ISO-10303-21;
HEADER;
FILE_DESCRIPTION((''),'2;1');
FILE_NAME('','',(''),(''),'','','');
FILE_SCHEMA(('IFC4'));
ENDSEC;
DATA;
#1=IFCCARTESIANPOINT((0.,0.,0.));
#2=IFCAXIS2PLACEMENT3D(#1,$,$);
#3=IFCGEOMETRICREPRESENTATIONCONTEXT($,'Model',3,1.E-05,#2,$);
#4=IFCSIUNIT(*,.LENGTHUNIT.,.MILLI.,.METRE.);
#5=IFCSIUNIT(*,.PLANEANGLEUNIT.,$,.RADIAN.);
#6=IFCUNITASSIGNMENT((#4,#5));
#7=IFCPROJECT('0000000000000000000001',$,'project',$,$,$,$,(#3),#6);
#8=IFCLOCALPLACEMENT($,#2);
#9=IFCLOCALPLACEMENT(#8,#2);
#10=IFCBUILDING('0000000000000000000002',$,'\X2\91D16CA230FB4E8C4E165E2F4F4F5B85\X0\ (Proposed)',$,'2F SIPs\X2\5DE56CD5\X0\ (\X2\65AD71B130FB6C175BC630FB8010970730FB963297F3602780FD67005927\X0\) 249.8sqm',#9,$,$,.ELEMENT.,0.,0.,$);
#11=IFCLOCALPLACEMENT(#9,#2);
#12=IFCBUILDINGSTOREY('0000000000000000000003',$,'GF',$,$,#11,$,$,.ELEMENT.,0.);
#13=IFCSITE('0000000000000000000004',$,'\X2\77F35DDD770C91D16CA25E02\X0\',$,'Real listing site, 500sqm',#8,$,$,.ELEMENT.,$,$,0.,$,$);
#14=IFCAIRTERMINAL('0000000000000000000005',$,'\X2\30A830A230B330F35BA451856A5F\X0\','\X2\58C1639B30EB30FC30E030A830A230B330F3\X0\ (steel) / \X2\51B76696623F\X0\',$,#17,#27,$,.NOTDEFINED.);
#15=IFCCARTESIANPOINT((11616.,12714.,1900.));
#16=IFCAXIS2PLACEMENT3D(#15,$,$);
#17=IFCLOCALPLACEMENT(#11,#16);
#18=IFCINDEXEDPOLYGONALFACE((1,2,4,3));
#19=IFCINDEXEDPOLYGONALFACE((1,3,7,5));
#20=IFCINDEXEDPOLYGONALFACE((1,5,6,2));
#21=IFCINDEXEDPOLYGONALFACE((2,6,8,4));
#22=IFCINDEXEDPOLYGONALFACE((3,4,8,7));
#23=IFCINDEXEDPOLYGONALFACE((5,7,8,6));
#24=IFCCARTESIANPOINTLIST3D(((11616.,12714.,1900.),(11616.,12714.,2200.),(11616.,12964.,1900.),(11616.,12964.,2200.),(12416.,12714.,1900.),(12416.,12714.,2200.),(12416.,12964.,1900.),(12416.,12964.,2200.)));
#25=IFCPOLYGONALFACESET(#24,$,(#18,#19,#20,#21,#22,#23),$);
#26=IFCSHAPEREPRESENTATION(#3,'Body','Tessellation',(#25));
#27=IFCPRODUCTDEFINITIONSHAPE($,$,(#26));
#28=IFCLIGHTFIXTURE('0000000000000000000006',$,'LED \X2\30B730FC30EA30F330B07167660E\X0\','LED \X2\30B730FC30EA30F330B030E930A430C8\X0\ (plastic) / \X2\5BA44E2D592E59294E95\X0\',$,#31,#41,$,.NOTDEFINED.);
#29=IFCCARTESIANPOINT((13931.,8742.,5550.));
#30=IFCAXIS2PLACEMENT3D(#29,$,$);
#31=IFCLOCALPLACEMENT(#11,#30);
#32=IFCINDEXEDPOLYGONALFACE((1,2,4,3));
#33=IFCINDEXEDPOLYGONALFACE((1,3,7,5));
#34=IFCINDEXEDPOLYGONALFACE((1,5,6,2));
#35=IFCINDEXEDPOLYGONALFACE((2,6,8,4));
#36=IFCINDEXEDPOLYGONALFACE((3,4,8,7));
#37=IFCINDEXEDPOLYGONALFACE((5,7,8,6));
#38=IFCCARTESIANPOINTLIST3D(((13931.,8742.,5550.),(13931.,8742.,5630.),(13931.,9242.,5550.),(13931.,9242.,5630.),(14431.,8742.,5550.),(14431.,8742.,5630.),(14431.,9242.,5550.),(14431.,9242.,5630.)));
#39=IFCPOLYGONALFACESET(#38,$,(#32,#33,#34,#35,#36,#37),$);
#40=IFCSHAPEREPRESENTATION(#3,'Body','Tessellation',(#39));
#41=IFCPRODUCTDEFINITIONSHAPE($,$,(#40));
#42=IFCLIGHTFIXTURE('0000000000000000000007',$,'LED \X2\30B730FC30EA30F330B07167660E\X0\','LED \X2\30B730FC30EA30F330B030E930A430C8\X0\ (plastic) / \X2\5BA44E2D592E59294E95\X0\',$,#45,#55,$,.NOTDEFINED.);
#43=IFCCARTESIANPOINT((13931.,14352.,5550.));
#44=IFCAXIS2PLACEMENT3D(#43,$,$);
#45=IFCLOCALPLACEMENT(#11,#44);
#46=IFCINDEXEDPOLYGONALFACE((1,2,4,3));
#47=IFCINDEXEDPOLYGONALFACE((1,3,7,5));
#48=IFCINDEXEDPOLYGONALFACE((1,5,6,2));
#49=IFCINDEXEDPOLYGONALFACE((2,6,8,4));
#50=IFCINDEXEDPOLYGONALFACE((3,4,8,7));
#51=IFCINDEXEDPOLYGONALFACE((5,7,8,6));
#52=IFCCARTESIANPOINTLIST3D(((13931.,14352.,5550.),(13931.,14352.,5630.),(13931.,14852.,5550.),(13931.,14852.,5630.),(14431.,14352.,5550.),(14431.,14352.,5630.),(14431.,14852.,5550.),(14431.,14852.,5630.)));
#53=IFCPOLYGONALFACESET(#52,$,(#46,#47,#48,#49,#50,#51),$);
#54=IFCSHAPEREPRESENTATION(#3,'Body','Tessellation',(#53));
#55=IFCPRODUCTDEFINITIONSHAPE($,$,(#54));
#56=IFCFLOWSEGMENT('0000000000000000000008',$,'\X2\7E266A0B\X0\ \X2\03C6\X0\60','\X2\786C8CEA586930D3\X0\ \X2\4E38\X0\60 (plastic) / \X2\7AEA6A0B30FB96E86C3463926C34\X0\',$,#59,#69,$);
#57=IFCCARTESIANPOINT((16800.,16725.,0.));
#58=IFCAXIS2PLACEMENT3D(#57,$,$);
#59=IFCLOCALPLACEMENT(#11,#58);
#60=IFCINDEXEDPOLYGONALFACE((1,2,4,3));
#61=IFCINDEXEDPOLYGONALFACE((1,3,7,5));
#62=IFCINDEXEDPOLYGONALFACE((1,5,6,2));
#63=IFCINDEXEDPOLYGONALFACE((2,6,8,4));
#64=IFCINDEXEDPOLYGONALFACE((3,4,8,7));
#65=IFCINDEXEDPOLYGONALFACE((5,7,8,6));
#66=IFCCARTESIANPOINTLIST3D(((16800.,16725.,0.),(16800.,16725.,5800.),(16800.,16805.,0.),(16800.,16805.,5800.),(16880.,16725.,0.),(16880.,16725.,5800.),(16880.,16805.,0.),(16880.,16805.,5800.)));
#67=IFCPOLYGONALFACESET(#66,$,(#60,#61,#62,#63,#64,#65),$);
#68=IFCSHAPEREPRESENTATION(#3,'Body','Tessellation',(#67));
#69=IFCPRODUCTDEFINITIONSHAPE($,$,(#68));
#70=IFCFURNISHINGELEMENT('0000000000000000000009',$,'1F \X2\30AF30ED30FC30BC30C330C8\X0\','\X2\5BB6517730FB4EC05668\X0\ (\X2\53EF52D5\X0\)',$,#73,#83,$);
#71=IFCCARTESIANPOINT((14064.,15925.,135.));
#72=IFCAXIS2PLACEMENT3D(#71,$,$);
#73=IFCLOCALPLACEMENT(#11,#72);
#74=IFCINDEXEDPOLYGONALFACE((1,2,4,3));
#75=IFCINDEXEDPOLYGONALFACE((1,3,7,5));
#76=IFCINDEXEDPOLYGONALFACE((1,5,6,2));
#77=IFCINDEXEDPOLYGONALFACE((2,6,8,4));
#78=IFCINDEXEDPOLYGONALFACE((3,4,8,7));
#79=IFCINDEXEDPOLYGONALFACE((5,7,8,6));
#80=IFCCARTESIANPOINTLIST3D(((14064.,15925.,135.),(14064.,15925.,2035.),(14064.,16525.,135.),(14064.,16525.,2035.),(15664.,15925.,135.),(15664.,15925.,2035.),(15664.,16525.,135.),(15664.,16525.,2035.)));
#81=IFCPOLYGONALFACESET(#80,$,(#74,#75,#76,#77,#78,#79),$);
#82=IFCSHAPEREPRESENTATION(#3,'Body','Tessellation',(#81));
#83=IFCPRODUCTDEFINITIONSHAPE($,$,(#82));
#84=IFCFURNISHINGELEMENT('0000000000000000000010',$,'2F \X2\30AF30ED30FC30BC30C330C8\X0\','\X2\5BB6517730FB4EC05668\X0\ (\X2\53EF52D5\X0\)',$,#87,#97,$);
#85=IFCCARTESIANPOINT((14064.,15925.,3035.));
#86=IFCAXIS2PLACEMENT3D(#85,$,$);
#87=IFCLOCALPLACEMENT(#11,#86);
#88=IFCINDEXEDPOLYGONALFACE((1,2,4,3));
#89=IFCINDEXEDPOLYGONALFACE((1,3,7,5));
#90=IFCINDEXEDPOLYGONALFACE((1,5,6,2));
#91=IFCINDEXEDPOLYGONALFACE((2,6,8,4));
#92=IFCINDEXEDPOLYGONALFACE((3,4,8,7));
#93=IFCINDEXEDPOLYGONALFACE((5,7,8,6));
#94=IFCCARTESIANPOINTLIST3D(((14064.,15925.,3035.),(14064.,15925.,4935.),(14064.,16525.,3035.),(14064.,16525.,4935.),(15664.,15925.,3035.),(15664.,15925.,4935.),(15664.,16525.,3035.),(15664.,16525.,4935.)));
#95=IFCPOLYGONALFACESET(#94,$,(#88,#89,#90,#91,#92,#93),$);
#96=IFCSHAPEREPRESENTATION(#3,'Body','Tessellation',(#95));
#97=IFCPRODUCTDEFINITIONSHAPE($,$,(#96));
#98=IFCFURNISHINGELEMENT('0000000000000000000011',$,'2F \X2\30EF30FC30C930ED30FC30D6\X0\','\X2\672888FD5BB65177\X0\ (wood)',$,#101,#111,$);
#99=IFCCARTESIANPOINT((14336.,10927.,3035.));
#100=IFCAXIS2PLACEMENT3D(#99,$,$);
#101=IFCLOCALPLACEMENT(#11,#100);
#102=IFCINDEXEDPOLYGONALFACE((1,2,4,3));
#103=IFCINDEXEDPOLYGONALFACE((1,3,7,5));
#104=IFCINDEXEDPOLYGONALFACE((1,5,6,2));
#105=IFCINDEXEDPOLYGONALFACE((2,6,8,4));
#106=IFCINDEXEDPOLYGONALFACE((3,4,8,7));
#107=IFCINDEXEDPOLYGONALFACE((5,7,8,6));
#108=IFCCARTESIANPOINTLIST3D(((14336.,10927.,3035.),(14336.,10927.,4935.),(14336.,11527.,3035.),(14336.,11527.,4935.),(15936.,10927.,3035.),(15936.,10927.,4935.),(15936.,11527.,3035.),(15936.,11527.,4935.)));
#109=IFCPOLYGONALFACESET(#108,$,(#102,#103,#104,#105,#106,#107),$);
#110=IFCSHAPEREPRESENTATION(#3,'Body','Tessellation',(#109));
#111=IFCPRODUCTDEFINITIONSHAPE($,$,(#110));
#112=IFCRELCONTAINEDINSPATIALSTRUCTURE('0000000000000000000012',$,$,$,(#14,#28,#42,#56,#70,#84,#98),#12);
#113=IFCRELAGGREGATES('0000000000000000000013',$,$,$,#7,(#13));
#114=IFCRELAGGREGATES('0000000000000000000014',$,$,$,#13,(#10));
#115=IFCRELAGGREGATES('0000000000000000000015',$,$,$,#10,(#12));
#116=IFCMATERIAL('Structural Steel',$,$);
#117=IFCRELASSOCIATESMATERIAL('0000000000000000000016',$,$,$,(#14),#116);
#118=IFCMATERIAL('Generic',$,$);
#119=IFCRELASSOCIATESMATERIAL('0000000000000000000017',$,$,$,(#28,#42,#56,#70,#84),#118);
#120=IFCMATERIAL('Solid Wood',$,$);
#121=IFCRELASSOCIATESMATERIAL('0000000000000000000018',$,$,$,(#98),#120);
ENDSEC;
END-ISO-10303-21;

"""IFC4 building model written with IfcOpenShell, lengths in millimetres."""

from ifc_helpers import new_model, si_unit, frame, frame_2d, origin, place, context, project, spatial, rectangle, extrude, material, element, save


model = new_model("IFC4")

# Units and contexts
model_context = context("Model", 3, precision=1e-05, world=origin())
ifc_project = project(units=[si_unit("LENGTHUNIT", "METRE", prefix="MILLI"), si_unit("PLANEANGLEUNIT", "RADIAN")], contexts=[model_context])

# Site, building, storey
site_placement = place(None, origin())
site = spatial("IfcSite", under=ifc_project, at=site_placement, Name="石川県金沢市", ObjectType="Real listing site, 500sqm", CompositionType="ELEMENT", RefElevation=0.0)
building_placement = place(site_placement, origin())
building = spatial("IfcBuilding", under=site, at=building_placement, Name="金沢・二世帯住宅 (Proposed)", ObjectType="2F SIPs工法 (断熱・気密・耐震・防音性能最大) 249.8sqm", CompositionType="ELEMENT", ElevationOfRefHeight=0.0, ElevationOfTerrain=0.0)
storey_placement = place(building_placement, origin())
storey = spatial("IfcBuildingStorey", under=building, at=storey_placement, Name="GF", CompositionType="ELEMENT", Elevation=0.0)

# Shared definitions
ifc_material_1 = material(Name="Solid Wood")
ifc_material_2 = material(Name="Structural Steel")

# Shared definitions
ifc_material_3 = material(Name="Generic")

# Air terminal
air_terminal_placement = place(storey_placement, frame((11616.0, 12714.0, 1900.0)))
element("IfcAirTerminal", 1, at=air_terminal_placement, inside=storey, material=ifc_material_2, Name="エアコン室内機", Description="壁掛ルームエアコン (steel) / 冷暖房", PredefinedType="NOTDEFINED", context=model_context, shape_type="SweptSolid", body=[
    extrude(rectangle(XDim=800.0, YDim=250.0, at=frame_2d((400.0, 125.0))), frame((11616.0, 12714.0, 1900.0)), (0.0, 0.0, 1.0), 300.0),
])

# Light fixtures
light_fixture_1_placement = place(storey_placement, frame((13931.0, 8742.0, 5550.0)))
element("IfcLightFixture", 2, at=light_fixture_1_placement, inside=storey, material=ifc_material_3, Name="LED シーリング照明", Description="LED シーリングライト (plastic) / 室中央天井", PredefinedType="NOTDEFINED", context=model_context, shape_type="SweptSolid", body=[
    extrude(rectangle(XDim=500.0, YDim=500.0, at=frame_2d((250.0, 250.0))), frame((13931.0, 8742.0, 5550.0)), (0.0, 0.0, 1.0), 80.0),
])
light_fixture_2_placement = place(storey_placement, frame((13931.0, 14352.0, 5550.0)))
element("IfcLightFixture", 3, at=light_fixture_2_placement, inside=storey, material=ifc_material_3, Name="LED シーリング照明", Description="LED シーリングライト (plastic) / 室中央天井", PredefinedType="NOTDEFINED", context=model_context, shape_type="SweptSolid", body=[
    extrude(rectangle(XDim=500.0, YDim=500.0, at=frame_2d((250.0, 250.0))), frame((13931.0, 14352.0, 5550.0)), (0.0, 0.0, 1.0), 80.0),
])

# Flow segment
flow_segment_placement = place(storey_placement, frame((16800.0, 16725.0, 0.0)))
element("IfcFlowSegment", 4, at=flow_segment_placement, inside=storey, material=ifc_material_3, Name="縦樋 φ60", Description="硬質塩ビ 丸60 (plastic) / 竪樋・雨水排水", context=model_context, shape_type="SweptSolid", body=[
    extrude(rectangle(XDim=80.0, YDim=80.0, at=frame_2d((40.0, 40.0))), frame((16800.0, 16725.0, 0.0)), (0.0, 0.0, 1.0), 5800.0),
])

# Furnishing elements
furnishing_1_placement = place(storey_placement, frame((14064.0, 15925.0, 135.0)))
element("IfcFurnishingElement", 5, at=furnishing_1_placement, inside=storey, material=ifc_material_3, Name="1F クローゼット", Description="家具・什器 (可動)", context=model_context, shape_type="SweptSolid", body=[
    extrude(rectangle(XDim=1600.0, YDim=600.0, at=frame_2d((800.0, 300.0))), frame((14064.0, 15925.0, 135.0)), (0.0, 0.0, 1.0), 1900.0),
])
furnishing_2_placement = place(storey_placement, frame((14064.0, 15925.0, 3035.0)))
element("IfcFurnishingElement", 6, at=furnishing_2_placement, inside=storey, material=ifc_material_3, Name="2F クローゼット", Description="家具・什器 (可動)", context=model_context, shape_type="SweptSolid", body=[
    extrude(rectangle(XDim=1600.0, YDim=600.0, at=frame_2d((800.0, 300.0))), frame((14064.0, 15925.0, 3035.0)), (0.0, 0.0, 1.0), 1900.0),
])
furnishing_3_placement = place(storey_placement, frame((14336.0, 10927.0, 3035.0)))
element("IfcFurnishingElement", 7, at=furnishing_3_placement, inside=storey, material=ifc_material_1, Name="2F ワードローブ", Description="木製家具 (wood)", context=model_context, shape_type="SweptSolid", body=[
    extrude(rectangle(XDim=1600.0, YDim=600.0, at=frame_2d((800.0, 300.0))), frame((14336.0, 10927.0, 3035.0)), (0.0, 0.0, 1.0), 1900.0),
])

save(model, "model.ifc")
